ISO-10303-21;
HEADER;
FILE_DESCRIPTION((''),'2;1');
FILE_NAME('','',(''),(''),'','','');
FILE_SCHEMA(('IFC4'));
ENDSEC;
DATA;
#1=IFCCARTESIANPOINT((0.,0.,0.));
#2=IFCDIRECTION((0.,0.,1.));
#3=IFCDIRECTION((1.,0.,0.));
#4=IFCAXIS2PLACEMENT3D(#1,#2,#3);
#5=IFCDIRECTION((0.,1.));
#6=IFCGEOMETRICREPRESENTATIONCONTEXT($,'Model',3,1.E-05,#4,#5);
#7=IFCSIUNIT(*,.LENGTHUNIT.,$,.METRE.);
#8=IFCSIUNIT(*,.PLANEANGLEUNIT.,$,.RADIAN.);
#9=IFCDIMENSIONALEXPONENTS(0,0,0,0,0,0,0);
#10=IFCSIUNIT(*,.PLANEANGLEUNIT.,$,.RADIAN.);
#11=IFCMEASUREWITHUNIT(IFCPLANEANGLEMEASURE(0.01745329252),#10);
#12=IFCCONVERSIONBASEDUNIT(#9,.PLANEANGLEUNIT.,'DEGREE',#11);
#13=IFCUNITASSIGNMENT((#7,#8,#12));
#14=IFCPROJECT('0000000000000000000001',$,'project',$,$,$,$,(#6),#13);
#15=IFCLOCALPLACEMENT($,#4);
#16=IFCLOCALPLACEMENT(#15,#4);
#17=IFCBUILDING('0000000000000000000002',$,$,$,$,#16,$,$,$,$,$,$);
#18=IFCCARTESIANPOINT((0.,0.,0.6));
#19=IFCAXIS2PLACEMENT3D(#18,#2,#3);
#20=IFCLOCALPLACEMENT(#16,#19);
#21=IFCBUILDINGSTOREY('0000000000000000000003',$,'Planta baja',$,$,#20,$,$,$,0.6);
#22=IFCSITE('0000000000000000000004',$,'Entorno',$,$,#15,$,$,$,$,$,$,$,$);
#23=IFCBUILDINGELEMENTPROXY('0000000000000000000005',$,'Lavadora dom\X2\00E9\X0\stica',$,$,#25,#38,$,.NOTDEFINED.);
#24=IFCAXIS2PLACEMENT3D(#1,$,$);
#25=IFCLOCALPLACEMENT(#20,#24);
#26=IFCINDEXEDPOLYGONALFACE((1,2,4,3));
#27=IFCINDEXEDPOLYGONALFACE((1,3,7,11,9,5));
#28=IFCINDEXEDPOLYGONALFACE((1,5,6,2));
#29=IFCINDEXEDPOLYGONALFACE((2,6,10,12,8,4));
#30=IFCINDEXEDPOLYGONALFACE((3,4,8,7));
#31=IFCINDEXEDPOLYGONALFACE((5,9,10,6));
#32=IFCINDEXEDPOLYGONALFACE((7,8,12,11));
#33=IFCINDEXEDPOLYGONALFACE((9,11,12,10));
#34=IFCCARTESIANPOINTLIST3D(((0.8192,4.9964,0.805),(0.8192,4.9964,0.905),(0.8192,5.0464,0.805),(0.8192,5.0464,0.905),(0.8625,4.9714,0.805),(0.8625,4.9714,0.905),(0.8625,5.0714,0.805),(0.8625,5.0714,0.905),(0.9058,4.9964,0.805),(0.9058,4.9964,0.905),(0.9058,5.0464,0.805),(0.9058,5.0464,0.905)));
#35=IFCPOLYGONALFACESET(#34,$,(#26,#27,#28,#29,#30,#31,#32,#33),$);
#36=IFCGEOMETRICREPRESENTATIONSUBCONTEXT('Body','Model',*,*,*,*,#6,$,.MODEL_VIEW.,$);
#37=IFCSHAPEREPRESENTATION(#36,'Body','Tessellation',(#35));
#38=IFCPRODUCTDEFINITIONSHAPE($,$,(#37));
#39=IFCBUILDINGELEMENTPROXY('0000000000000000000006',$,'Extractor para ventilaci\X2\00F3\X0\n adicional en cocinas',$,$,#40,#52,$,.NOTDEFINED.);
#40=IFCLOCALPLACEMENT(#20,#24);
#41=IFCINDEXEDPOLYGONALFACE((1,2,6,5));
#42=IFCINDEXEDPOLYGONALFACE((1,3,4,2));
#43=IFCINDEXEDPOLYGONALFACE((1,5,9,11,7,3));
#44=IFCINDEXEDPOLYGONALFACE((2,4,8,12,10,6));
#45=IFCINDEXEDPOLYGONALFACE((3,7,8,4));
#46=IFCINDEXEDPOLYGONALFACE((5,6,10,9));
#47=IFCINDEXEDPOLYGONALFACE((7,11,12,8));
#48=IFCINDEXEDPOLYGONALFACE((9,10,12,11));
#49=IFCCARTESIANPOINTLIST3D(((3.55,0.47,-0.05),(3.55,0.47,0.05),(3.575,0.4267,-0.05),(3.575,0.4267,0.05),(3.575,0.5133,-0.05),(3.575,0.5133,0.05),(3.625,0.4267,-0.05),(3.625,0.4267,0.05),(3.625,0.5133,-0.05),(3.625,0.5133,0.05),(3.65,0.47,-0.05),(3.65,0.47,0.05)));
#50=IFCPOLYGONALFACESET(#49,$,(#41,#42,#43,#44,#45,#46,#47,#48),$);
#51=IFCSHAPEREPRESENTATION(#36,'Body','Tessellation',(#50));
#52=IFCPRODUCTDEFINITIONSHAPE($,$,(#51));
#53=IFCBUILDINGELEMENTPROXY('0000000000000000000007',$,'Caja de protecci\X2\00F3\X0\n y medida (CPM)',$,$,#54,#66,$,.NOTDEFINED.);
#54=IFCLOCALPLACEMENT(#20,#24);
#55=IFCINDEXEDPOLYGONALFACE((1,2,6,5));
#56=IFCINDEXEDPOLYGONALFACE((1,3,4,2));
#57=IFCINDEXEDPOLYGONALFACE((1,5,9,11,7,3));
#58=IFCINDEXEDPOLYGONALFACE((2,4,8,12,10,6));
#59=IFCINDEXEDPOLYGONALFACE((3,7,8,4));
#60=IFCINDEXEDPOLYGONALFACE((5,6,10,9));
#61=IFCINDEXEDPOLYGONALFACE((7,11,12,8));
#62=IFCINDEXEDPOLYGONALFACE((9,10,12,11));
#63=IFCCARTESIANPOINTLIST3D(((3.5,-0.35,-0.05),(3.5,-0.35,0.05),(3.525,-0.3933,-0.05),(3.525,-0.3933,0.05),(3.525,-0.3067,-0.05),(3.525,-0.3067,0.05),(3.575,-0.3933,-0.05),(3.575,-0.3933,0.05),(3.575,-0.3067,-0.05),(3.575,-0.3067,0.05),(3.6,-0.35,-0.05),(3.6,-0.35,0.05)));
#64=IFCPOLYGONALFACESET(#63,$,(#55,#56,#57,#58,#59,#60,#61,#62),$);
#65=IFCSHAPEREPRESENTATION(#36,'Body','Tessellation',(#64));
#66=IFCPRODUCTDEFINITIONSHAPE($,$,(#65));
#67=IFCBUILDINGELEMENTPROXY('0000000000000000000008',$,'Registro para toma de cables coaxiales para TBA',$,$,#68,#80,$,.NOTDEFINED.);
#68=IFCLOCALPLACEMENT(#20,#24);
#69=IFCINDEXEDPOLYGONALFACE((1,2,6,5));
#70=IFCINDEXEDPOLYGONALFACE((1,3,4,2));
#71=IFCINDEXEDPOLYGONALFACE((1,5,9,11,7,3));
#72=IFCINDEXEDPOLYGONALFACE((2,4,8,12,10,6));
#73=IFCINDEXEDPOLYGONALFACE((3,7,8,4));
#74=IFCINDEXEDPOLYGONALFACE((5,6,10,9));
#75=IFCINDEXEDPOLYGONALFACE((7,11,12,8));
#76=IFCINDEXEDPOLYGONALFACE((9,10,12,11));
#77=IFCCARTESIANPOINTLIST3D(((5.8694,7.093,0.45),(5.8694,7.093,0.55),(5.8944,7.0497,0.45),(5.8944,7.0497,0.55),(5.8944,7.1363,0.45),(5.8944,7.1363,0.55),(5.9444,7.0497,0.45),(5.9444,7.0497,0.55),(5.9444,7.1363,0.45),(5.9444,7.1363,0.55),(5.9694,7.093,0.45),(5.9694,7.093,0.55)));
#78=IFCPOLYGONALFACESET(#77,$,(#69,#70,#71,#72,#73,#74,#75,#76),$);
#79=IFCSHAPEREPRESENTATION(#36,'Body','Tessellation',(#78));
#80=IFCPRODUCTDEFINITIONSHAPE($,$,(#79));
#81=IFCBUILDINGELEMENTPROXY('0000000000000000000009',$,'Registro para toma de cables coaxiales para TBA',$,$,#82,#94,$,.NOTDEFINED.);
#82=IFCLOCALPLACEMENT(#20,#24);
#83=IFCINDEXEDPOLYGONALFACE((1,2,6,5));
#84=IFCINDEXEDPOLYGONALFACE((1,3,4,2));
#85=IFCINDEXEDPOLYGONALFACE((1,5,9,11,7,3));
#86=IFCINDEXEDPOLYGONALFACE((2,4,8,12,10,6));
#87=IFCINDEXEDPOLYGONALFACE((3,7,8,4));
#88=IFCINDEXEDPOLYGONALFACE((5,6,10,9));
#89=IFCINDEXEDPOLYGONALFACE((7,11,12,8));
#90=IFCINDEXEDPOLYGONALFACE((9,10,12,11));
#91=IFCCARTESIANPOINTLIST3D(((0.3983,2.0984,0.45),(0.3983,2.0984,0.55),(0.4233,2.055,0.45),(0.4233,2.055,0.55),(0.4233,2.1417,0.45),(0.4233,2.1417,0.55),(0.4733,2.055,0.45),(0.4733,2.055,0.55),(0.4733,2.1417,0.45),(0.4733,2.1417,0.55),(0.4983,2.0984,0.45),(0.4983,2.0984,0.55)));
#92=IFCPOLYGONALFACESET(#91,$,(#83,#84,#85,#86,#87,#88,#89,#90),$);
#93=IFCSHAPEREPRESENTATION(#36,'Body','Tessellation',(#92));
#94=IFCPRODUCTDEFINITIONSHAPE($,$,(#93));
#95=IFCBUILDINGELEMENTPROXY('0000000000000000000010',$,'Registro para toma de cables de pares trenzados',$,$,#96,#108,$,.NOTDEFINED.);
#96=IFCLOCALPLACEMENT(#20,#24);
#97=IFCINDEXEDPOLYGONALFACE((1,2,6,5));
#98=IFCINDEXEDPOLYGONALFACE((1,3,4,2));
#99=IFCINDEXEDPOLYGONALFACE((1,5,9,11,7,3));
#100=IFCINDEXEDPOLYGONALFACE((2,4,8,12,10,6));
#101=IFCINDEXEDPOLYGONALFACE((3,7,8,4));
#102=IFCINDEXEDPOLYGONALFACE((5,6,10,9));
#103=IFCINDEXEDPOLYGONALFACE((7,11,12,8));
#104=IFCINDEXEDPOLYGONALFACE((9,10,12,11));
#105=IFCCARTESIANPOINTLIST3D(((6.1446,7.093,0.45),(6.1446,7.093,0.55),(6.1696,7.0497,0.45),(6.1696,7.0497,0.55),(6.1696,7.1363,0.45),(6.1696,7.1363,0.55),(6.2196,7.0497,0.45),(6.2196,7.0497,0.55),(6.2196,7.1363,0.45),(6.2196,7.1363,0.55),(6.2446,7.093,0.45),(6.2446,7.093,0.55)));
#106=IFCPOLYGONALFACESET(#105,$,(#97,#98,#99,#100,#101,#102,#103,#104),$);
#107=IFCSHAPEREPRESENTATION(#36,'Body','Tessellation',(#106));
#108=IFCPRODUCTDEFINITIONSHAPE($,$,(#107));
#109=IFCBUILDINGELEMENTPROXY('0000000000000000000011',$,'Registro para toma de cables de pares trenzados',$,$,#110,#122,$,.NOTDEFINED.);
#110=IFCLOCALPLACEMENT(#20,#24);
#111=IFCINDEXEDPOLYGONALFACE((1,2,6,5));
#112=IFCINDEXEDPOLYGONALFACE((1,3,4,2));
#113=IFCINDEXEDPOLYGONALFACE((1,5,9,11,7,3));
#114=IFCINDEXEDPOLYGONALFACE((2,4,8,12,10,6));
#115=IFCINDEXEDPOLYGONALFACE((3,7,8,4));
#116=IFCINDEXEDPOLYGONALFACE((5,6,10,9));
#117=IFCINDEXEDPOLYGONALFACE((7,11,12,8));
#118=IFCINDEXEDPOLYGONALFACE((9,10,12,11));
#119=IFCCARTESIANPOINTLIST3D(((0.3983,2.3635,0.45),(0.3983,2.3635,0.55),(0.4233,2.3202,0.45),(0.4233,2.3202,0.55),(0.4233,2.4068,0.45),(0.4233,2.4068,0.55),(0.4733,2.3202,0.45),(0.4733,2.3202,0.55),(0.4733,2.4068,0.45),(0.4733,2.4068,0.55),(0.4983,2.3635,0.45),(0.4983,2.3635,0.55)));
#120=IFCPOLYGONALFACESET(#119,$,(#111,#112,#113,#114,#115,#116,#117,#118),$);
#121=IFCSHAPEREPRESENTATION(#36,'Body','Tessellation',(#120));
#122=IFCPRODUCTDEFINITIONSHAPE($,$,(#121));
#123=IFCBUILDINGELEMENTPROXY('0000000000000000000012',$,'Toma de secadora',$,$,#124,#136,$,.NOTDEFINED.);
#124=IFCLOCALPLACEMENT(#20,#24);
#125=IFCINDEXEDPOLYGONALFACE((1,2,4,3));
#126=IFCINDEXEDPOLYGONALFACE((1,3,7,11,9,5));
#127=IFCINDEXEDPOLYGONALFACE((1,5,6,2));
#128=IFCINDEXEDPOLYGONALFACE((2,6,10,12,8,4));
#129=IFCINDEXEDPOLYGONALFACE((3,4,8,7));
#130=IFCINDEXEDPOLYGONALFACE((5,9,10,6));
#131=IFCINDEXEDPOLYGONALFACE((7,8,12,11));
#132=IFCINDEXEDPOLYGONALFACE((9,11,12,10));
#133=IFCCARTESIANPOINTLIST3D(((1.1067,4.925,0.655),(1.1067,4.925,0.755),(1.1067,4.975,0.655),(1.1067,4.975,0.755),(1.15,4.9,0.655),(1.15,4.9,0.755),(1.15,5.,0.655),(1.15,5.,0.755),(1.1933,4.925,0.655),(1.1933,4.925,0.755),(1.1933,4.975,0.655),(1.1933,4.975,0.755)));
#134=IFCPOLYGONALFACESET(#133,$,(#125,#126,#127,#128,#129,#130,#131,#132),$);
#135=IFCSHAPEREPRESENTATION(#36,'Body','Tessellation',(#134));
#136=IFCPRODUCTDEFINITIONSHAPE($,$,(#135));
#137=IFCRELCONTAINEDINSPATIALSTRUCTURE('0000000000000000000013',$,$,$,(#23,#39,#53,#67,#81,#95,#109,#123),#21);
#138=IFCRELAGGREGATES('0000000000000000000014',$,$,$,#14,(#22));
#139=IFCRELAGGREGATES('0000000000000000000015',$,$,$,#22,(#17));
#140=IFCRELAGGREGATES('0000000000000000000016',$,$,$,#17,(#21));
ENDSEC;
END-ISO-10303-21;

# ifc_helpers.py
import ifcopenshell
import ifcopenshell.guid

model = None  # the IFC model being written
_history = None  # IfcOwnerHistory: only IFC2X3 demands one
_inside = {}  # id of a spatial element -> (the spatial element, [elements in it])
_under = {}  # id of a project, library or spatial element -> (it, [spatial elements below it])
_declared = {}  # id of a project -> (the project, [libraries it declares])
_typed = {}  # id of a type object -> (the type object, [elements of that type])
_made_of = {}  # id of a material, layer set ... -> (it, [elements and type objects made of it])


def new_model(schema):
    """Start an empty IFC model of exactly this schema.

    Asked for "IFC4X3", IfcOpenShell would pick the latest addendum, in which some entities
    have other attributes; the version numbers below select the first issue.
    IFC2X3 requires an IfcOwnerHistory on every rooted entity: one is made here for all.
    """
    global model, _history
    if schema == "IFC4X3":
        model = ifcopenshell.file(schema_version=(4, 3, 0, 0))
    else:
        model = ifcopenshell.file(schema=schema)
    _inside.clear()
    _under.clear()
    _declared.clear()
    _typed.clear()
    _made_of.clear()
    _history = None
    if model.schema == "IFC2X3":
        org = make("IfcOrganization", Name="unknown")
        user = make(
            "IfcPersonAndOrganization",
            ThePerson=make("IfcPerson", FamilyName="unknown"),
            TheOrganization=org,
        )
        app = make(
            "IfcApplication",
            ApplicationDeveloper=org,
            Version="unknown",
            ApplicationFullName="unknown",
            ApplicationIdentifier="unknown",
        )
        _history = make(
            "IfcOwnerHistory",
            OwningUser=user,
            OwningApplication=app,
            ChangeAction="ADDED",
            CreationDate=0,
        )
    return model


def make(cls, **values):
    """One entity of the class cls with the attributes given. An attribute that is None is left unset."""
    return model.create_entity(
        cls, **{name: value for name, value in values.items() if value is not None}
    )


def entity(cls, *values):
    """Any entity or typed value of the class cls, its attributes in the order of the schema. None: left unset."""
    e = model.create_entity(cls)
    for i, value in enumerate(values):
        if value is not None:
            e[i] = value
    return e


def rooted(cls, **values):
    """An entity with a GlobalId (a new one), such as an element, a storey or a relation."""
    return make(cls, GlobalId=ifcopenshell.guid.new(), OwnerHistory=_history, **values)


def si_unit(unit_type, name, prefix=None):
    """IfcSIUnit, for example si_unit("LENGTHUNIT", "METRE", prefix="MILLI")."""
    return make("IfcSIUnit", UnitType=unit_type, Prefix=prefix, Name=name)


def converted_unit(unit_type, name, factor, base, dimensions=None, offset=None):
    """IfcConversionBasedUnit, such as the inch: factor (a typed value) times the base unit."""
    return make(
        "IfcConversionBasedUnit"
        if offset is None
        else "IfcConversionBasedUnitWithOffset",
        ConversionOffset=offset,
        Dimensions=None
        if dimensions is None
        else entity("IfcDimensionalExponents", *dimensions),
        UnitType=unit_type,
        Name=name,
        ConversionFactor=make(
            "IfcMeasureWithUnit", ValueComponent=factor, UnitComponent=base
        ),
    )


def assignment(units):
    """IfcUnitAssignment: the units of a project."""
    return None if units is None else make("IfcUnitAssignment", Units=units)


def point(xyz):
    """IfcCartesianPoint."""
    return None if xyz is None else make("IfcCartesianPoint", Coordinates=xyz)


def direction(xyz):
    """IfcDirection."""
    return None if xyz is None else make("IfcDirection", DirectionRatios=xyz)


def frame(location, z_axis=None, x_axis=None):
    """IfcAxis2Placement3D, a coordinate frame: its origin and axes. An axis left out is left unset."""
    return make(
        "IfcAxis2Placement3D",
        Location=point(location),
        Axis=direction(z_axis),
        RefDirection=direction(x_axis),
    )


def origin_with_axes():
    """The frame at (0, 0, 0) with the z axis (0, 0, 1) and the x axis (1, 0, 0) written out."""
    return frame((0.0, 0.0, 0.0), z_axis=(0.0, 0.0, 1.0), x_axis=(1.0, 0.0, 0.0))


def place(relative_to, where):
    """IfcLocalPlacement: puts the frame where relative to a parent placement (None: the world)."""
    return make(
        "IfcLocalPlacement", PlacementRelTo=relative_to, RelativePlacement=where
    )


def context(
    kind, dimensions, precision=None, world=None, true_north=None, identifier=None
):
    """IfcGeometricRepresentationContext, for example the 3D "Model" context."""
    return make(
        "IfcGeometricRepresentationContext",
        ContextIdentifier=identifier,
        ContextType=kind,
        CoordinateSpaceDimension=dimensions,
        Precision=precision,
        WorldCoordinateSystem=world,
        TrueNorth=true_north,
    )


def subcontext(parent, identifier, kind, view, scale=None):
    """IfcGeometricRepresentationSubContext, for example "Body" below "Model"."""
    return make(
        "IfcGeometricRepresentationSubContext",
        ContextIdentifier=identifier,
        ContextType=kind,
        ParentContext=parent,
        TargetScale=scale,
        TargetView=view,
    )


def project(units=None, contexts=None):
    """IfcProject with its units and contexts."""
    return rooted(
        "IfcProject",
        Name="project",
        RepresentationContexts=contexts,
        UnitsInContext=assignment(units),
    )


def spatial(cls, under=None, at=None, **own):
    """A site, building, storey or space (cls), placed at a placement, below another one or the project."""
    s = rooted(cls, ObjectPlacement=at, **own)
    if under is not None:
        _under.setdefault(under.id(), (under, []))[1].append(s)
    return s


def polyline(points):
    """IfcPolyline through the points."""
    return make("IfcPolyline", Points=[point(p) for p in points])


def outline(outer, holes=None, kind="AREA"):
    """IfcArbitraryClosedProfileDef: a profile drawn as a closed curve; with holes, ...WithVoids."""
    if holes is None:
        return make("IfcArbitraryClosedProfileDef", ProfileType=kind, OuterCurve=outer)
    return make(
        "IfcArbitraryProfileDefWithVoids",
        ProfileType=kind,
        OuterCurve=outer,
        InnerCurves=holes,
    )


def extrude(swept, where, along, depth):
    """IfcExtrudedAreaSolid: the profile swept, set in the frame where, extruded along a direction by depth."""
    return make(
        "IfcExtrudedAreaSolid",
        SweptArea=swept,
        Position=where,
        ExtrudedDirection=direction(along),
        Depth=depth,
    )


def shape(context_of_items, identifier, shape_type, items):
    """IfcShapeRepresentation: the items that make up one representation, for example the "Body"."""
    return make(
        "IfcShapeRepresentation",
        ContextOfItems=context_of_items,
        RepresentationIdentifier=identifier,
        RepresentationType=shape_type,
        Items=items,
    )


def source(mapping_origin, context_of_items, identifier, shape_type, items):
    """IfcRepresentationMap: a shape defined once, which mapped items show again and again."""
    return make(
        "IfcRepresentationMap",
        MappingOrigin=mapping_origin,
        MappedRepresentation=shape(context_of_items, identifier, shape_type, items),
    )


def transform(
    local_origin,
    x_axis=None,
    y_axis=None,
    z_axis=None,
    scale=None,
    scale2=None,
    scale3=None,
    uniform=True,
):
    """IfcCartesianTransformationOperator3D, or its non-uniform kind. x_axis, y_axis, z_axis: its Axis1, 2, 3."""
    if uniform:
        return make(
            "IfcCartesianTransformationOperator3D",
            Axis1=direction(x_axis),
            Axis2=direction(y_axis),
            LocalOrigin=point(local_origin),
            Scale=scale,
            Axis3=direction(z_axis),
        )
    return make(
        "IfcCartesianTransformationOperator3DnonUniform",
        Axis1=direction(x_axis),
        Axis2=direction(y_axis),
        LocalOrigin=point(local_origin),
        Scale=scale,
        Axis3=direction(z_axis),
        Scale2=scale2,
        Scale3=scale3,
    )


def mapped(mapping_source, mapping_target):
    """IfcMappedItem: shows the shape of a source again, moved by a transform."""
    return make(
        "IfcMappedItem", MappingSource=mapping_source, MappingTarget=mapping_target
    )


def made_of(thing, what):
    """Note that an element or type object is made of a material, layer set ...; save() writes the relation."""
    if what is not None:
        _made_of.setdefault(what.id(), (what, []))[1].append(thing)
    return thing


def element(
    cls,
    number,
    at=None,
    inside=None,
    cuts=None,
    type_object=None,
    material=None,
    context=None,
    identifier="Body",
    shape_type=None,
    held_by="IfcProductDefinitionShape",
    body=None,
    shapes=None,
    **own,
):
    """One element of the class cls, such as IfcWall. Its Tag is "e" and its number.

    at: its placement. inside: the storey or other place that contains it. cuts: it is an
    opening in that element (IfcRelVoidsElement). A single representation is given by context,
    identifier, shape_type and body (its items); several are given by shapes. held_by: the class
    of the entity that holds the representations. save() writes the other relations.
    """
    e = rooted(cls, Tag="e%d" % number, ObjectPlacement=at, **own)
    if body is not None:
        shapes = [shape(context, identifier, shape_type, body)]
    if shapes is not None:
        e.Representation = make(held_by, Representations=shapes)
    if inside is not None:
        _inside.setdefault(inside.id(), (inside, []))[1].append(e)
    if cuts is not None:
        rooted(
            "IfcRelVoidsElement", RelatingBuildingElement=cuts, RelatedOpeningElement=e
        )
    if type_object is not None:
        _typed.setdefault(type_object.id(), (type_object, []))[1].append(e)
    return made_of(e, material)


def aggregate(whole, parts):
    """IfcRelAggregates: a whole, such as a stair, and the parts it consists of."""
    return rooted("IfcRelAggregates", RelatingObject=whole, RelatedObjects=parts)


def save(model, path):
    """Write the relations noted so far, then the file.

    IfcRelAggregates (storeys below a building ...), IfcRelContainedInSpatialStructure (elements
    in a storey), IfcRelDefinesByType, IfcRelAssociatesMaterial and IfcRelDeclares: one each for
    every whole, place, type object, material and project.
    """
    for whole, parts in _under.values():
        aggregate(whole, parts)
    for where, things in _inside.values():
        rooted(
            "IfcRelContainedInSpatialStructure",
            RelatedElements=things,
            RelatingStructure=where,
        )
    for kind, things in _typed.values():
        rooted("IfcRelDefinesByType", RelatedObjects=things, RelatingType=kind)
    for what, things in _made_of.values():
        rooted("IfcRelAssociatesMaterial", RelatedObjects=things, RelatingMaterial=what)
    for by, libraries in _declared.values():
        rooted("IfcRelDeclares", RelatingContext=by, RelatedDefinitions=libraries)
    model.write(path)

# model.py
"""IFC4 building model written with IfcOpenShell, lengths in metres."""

from ifc_helpers import new_model, entity, si_unit, converted_unit, direction, frame, origin_with_axes, place, context, subcontext, project, spatial, polyline, outline, extrude, source, transform, mapped, element, save


model = new_model("IFC4")

# Units and contexts
model_context = context("Model", 3, precision=1e-05, world=origin_with_axes(), true_north=direction((0.0, 1.0)))
body_context = subcontext(model_context, "Body", "Model", "MODEL_VIEW")
ifc_project = project(units=[si_unit("LENGTHUNIT", "METRE"), si_unit("PLANEANGLEUNIT", "RADIAN"), converted_unit("PLANEANGLEUNIT", "DEGREE", entity("IfcPlaneAngleMeasure", 0.01745329252), si_unit("PLANEANGLEUNIT", "RADIAN"), dimensions=[0, 0, 0, 0, 0, 0, 0])], contexts=[model_context])

# Site, building, storey
site_placement = place(None, origin_with_axes())
site = spatial("IfcSite", under=ifc_project, at=site_placement, Name="Entorno")
building_placement = place(site_placement, origin_with_axes())
building = spatial("IfcBuilding", under=site, at=building_placement)
storey_placement = place(building_placement, frame((0.0, 0.0, 0.6), z_axis=(0.0, 0.0, 1.0), x_axis=(1.0, 0.0, 0.0)))
storey = spatial("IfcBuildingStorey", under=building, at=storey_placement, Name="Planta baja", Elevation=0.6)

# Building element proxies
shared_shape_1 = source(origin_with_axes(), body_context, "Body", "SolidModel", [
    extrude(outline(polyline([(0.05, 0.0), (0.025, 0.0433), (-0.025, 0.0433), (-0.05, 0.0), (-0.025, -0.0433), (0.025, -0.0433), (0.05, 0.0)])), frame((0.0, 0.0, -0.05), z_axis=(0.0, 0.0, 1.0), x_axis=(1.0, 0.0, 0.0)), (0.0, 0.0, 1.0), 0.1),
])
proxy_1_placement = place(storey_placement, frame((0.0, 0.0, -0.6), z_axis=(0.0, 0.0, 1.0), x_axis=(1.0, 0.0, 0.0)))
element("IfcBuildingElementProxy", 1, at=proxy_1_placement, inside=storey, Name="Lavadora doméstica", PredefinedType="NOTDEFINED", context=body_context, shape_type="Brep", body=[
    mapped(shared_shape_1, transform((0.8625, 5.0214, 1.455), x_axis=(0.0, 1.0, 0.0), y_axis=(-1.0, 0.0, 0.0), z_axis=(0.0, 0.0, 1.0))),
])
shared_shape_2 = source(origin_with_axes(), body_context, "Body", "SolidModel", [
    extrude(outline(polyline([(0.05, 0.0), (0.025, 0.0433), (-0.025, 0.0433), (-0.05, 0.0), (-0.025, -0.0433), (0.025, -0.0433), (0.05, 0.0)])), frame((0.0, 0.0, -0.05), z_axis=(0.0, 0.0, 1.0), x_axis=(1.0, 0.0, 0.0)), (0.0, 0.0, 1.0), 0.1),
])
proxy_2_placement = place(storey_placement, frame((0.0, 0.0, -0.6), z_axis=(0.0, 0.0, 1.0), x_axis=(1.0, 0.0, 0.0)))
element("IfcBuildingElementProxy", 2, at=proxy_2_placement, inside=storey, Name="Extractor para ventilación adicional en cocinas", PredefinedType="NOTDEFINED", context=body_context, shape_type="Brep", body=[
    mapped(shared_shape_2, transform((3.6, 0.47, 0.6), x_axis=(-1.0, 0.0, 0.0), y_axis=(0.0, -1.0, 0.0), z_axis=(0.0, 0.0, 1.0))),
])
shared_shape_3 = source(origin_with_axes(), body_context, "Body", "SolidModel", [
    extrude(outline(polyline([(0.05, 0.0), (0.025, 0.0433), (-0.025, 0.0433), (-0.05, 0.0), (-0.025, -0.0433), (0.025, -0.0433), (0.05, 0.0)])), frame((0.0, 0.0, -0.05), z_axis=(0.0, 0.0, 1.0), x_axis=(1.0, 0.0, 0.0)), (0.0, 0.0, 1.0), 0.1),
])
proxy_3_placement = place(storey_placement, frame((0.0, 0.0, -0.6), z_axis=(0.0, 0.0, 1.0), x_axis=(1.0, 0.0, 0.0)))
element("IfcBuildingElementProxy", 3, at=proxy_3_placement, inside=storey, Name="Caja de protección y medida (CPM)", PredefinedType="NOTDEFINED", context=body_context, shape_type="Brep", body=[
    mapped(shared_shape_3, transform((3.55, -0.35, 0.6), x_axis=(1.0, 0.0, 0.0), y_axis=(0.0, 1.0, 0.0), z_axis=(0.0, 0.0, 1.0))),
])
shared_shape_4 = source(origin_with_axes(), body_context, "Body", "SolidModel", [
    extrude(outline(polyline([(0.05, 0.0), (0.025, 0.0433), (-0.025, 0.0433), (-0.05, 0.0), (-0.025, -0.0433), (0.025, -0.0433), (0.05, 0.0)])), frame((0.0, 0.0, -0.05), z_axis=(0.0, 0.0, 1.0), x_axis=(1.0, 0.0, 0.0)), (0.0, 0.0, 1.0), 0.1),
])
proxy_4_placement = place(storey_placement, frame((0.0, 0.0, -0.6), z_axis=(0.0, 0.0, 1.0), x_axis=(1.0, 0.0, 0.0)))
element("IfcBuildingElementProxy", 4, at=proxy_4_placement, inside=storey, Name="Registro para toma de cables coaxiales para TBA", PredefinedType="NOTDEFINED", context=body_context, shape_type="Brep", body=[
    mapped(shared_shape_4, transform((5.9194, 7.093, 1.1), x_axis=(1.0, 0.0, 0.0), y_axis=(0.0, 1.0, 0.0), z_axis=(0.0, 0.0, 1.0))),
])
proxy_5_placement = place(storey_placement, frame((0.0, 0.0, -0.6), z_axis=(0.0, 0.0, 1.0), x_axis=(1.0, 0.0, 0.0)))
element("IfcBuildingElementProxy", 5, at=proxy_5_placement, inside=storey, Name="Registro para toma de cables coaxiales para TBA", PredefinedType="NOTDEFINED", context=body_context, shape_type="Brep", body=[
    mapped(shared_shape_4, transform((0.4483, 2.0984, 1.1), x_axis=(1.0, 0.0, 0.0), y_axis=(0.0, 1.0, 0.0), z_axis=(0.0, 0.0, 1.0))),
])
shared_shape_5 = source(origin_with_axes(), body_context, "Body", "SolidModel", [
    extrude(outline(polyline([(0.05, 0.0), (0.025, 0.0433), (-0.025, 0.0433), (-0.05, 0.0), (-0.025, -0.0433), (0.025, -0.0433), (0.05, 0.0)])), frame((0.0, 0.0, -0.05), z_axis=(0.0, 0.0, 1.0), x_axis=(1.0, 0.0, 0.0)), (0.0, 0.0, 1.0), 0.1),
])
proxy_6_placement = place(storey_placement, frame((0.0, 0.0, -0.6), z_axis=(0.0, 0.0, 1.0), x_axis=(1.0, 0.0, 0.0)))
element("IfcBuildingElementProxy", 6, at=proxy_6_placement, inside=storey, Name="Registro para toma de cables de pares trenzados", PredefinedType="NOTDEFINED", context=body_context, shape_type="Brep", body=[
    mapped(shared_shape_5, transform((6.1946, 7.093, 1.1), x_axis=(1.0, 0.0, 0.0), y_axis=(0.0, 1.0, 0.0), z_axis=(0.0, 0.0, 1.0))),
])
proxy_7_placement = place(storey_placement, frame((0.0, 0.0, -0.6), z_axis=(0.0, 0.0, 1.0), x_axis=(1.0, 0.0, 0.0)))
element("IfcBuildingElementProxy", 7, at=proxy_7_placement, inside=storey, Name="Registro para toma de cables de pares trenzados", PredefinedType="NOTDEFINED", context=body_context, shape_type="Brep", body=[
    mapped(shared_shape_5, transform((0.4483, 2.3635, 1.1), x_axis=(1.0, 0.0, 0.0), y_axis=(0.0, 1.0, 0.0), z_axis=(0.0, 0.0, 1.0))),
])
shared_shape_6 = source(origin_with_axes(), body_context, "Body", "SolidModel", [
    extrude(outline(polyline([(0.05, 0.0), (0.025, 0.0433), (-0.025, 0.0433), (-0.05, 0.0), (-0.025, -0.0433), (0.025, -0.0433), (0.05, 0.0)])), frame((0.0, 0.0, -0.05), z_axis=(0.0, 0.0, 1.0), x_axis=(1.0, 0.0, 0.0)), (0.0, 0.0, 1.0), 0.1),
])
proxy_8_placement = place(storey_placement, frame((0.0, 0.0, -0.6), z_axis=(0.0, 0.0, 1.0), x_axis=(1.0, 0.0, 0.0)))
element("IfcBuildingElementProxy", 8, at=proxy_8_placement, inside=storey, Name="Toma de secadora", PredefinedType="NOTDEFINED", context=body_context, shape_type="Brep", body=[
    mapped(shared_shape_6, transform((1.15, 4.95, 1.305), x_axis=(0.0, -1.0, 0.0), y_axis=(1.0, 0.0, 0.0), z_axis=(0.0, 0.0, 1.0))),
])

save(model, "model.ifc")
